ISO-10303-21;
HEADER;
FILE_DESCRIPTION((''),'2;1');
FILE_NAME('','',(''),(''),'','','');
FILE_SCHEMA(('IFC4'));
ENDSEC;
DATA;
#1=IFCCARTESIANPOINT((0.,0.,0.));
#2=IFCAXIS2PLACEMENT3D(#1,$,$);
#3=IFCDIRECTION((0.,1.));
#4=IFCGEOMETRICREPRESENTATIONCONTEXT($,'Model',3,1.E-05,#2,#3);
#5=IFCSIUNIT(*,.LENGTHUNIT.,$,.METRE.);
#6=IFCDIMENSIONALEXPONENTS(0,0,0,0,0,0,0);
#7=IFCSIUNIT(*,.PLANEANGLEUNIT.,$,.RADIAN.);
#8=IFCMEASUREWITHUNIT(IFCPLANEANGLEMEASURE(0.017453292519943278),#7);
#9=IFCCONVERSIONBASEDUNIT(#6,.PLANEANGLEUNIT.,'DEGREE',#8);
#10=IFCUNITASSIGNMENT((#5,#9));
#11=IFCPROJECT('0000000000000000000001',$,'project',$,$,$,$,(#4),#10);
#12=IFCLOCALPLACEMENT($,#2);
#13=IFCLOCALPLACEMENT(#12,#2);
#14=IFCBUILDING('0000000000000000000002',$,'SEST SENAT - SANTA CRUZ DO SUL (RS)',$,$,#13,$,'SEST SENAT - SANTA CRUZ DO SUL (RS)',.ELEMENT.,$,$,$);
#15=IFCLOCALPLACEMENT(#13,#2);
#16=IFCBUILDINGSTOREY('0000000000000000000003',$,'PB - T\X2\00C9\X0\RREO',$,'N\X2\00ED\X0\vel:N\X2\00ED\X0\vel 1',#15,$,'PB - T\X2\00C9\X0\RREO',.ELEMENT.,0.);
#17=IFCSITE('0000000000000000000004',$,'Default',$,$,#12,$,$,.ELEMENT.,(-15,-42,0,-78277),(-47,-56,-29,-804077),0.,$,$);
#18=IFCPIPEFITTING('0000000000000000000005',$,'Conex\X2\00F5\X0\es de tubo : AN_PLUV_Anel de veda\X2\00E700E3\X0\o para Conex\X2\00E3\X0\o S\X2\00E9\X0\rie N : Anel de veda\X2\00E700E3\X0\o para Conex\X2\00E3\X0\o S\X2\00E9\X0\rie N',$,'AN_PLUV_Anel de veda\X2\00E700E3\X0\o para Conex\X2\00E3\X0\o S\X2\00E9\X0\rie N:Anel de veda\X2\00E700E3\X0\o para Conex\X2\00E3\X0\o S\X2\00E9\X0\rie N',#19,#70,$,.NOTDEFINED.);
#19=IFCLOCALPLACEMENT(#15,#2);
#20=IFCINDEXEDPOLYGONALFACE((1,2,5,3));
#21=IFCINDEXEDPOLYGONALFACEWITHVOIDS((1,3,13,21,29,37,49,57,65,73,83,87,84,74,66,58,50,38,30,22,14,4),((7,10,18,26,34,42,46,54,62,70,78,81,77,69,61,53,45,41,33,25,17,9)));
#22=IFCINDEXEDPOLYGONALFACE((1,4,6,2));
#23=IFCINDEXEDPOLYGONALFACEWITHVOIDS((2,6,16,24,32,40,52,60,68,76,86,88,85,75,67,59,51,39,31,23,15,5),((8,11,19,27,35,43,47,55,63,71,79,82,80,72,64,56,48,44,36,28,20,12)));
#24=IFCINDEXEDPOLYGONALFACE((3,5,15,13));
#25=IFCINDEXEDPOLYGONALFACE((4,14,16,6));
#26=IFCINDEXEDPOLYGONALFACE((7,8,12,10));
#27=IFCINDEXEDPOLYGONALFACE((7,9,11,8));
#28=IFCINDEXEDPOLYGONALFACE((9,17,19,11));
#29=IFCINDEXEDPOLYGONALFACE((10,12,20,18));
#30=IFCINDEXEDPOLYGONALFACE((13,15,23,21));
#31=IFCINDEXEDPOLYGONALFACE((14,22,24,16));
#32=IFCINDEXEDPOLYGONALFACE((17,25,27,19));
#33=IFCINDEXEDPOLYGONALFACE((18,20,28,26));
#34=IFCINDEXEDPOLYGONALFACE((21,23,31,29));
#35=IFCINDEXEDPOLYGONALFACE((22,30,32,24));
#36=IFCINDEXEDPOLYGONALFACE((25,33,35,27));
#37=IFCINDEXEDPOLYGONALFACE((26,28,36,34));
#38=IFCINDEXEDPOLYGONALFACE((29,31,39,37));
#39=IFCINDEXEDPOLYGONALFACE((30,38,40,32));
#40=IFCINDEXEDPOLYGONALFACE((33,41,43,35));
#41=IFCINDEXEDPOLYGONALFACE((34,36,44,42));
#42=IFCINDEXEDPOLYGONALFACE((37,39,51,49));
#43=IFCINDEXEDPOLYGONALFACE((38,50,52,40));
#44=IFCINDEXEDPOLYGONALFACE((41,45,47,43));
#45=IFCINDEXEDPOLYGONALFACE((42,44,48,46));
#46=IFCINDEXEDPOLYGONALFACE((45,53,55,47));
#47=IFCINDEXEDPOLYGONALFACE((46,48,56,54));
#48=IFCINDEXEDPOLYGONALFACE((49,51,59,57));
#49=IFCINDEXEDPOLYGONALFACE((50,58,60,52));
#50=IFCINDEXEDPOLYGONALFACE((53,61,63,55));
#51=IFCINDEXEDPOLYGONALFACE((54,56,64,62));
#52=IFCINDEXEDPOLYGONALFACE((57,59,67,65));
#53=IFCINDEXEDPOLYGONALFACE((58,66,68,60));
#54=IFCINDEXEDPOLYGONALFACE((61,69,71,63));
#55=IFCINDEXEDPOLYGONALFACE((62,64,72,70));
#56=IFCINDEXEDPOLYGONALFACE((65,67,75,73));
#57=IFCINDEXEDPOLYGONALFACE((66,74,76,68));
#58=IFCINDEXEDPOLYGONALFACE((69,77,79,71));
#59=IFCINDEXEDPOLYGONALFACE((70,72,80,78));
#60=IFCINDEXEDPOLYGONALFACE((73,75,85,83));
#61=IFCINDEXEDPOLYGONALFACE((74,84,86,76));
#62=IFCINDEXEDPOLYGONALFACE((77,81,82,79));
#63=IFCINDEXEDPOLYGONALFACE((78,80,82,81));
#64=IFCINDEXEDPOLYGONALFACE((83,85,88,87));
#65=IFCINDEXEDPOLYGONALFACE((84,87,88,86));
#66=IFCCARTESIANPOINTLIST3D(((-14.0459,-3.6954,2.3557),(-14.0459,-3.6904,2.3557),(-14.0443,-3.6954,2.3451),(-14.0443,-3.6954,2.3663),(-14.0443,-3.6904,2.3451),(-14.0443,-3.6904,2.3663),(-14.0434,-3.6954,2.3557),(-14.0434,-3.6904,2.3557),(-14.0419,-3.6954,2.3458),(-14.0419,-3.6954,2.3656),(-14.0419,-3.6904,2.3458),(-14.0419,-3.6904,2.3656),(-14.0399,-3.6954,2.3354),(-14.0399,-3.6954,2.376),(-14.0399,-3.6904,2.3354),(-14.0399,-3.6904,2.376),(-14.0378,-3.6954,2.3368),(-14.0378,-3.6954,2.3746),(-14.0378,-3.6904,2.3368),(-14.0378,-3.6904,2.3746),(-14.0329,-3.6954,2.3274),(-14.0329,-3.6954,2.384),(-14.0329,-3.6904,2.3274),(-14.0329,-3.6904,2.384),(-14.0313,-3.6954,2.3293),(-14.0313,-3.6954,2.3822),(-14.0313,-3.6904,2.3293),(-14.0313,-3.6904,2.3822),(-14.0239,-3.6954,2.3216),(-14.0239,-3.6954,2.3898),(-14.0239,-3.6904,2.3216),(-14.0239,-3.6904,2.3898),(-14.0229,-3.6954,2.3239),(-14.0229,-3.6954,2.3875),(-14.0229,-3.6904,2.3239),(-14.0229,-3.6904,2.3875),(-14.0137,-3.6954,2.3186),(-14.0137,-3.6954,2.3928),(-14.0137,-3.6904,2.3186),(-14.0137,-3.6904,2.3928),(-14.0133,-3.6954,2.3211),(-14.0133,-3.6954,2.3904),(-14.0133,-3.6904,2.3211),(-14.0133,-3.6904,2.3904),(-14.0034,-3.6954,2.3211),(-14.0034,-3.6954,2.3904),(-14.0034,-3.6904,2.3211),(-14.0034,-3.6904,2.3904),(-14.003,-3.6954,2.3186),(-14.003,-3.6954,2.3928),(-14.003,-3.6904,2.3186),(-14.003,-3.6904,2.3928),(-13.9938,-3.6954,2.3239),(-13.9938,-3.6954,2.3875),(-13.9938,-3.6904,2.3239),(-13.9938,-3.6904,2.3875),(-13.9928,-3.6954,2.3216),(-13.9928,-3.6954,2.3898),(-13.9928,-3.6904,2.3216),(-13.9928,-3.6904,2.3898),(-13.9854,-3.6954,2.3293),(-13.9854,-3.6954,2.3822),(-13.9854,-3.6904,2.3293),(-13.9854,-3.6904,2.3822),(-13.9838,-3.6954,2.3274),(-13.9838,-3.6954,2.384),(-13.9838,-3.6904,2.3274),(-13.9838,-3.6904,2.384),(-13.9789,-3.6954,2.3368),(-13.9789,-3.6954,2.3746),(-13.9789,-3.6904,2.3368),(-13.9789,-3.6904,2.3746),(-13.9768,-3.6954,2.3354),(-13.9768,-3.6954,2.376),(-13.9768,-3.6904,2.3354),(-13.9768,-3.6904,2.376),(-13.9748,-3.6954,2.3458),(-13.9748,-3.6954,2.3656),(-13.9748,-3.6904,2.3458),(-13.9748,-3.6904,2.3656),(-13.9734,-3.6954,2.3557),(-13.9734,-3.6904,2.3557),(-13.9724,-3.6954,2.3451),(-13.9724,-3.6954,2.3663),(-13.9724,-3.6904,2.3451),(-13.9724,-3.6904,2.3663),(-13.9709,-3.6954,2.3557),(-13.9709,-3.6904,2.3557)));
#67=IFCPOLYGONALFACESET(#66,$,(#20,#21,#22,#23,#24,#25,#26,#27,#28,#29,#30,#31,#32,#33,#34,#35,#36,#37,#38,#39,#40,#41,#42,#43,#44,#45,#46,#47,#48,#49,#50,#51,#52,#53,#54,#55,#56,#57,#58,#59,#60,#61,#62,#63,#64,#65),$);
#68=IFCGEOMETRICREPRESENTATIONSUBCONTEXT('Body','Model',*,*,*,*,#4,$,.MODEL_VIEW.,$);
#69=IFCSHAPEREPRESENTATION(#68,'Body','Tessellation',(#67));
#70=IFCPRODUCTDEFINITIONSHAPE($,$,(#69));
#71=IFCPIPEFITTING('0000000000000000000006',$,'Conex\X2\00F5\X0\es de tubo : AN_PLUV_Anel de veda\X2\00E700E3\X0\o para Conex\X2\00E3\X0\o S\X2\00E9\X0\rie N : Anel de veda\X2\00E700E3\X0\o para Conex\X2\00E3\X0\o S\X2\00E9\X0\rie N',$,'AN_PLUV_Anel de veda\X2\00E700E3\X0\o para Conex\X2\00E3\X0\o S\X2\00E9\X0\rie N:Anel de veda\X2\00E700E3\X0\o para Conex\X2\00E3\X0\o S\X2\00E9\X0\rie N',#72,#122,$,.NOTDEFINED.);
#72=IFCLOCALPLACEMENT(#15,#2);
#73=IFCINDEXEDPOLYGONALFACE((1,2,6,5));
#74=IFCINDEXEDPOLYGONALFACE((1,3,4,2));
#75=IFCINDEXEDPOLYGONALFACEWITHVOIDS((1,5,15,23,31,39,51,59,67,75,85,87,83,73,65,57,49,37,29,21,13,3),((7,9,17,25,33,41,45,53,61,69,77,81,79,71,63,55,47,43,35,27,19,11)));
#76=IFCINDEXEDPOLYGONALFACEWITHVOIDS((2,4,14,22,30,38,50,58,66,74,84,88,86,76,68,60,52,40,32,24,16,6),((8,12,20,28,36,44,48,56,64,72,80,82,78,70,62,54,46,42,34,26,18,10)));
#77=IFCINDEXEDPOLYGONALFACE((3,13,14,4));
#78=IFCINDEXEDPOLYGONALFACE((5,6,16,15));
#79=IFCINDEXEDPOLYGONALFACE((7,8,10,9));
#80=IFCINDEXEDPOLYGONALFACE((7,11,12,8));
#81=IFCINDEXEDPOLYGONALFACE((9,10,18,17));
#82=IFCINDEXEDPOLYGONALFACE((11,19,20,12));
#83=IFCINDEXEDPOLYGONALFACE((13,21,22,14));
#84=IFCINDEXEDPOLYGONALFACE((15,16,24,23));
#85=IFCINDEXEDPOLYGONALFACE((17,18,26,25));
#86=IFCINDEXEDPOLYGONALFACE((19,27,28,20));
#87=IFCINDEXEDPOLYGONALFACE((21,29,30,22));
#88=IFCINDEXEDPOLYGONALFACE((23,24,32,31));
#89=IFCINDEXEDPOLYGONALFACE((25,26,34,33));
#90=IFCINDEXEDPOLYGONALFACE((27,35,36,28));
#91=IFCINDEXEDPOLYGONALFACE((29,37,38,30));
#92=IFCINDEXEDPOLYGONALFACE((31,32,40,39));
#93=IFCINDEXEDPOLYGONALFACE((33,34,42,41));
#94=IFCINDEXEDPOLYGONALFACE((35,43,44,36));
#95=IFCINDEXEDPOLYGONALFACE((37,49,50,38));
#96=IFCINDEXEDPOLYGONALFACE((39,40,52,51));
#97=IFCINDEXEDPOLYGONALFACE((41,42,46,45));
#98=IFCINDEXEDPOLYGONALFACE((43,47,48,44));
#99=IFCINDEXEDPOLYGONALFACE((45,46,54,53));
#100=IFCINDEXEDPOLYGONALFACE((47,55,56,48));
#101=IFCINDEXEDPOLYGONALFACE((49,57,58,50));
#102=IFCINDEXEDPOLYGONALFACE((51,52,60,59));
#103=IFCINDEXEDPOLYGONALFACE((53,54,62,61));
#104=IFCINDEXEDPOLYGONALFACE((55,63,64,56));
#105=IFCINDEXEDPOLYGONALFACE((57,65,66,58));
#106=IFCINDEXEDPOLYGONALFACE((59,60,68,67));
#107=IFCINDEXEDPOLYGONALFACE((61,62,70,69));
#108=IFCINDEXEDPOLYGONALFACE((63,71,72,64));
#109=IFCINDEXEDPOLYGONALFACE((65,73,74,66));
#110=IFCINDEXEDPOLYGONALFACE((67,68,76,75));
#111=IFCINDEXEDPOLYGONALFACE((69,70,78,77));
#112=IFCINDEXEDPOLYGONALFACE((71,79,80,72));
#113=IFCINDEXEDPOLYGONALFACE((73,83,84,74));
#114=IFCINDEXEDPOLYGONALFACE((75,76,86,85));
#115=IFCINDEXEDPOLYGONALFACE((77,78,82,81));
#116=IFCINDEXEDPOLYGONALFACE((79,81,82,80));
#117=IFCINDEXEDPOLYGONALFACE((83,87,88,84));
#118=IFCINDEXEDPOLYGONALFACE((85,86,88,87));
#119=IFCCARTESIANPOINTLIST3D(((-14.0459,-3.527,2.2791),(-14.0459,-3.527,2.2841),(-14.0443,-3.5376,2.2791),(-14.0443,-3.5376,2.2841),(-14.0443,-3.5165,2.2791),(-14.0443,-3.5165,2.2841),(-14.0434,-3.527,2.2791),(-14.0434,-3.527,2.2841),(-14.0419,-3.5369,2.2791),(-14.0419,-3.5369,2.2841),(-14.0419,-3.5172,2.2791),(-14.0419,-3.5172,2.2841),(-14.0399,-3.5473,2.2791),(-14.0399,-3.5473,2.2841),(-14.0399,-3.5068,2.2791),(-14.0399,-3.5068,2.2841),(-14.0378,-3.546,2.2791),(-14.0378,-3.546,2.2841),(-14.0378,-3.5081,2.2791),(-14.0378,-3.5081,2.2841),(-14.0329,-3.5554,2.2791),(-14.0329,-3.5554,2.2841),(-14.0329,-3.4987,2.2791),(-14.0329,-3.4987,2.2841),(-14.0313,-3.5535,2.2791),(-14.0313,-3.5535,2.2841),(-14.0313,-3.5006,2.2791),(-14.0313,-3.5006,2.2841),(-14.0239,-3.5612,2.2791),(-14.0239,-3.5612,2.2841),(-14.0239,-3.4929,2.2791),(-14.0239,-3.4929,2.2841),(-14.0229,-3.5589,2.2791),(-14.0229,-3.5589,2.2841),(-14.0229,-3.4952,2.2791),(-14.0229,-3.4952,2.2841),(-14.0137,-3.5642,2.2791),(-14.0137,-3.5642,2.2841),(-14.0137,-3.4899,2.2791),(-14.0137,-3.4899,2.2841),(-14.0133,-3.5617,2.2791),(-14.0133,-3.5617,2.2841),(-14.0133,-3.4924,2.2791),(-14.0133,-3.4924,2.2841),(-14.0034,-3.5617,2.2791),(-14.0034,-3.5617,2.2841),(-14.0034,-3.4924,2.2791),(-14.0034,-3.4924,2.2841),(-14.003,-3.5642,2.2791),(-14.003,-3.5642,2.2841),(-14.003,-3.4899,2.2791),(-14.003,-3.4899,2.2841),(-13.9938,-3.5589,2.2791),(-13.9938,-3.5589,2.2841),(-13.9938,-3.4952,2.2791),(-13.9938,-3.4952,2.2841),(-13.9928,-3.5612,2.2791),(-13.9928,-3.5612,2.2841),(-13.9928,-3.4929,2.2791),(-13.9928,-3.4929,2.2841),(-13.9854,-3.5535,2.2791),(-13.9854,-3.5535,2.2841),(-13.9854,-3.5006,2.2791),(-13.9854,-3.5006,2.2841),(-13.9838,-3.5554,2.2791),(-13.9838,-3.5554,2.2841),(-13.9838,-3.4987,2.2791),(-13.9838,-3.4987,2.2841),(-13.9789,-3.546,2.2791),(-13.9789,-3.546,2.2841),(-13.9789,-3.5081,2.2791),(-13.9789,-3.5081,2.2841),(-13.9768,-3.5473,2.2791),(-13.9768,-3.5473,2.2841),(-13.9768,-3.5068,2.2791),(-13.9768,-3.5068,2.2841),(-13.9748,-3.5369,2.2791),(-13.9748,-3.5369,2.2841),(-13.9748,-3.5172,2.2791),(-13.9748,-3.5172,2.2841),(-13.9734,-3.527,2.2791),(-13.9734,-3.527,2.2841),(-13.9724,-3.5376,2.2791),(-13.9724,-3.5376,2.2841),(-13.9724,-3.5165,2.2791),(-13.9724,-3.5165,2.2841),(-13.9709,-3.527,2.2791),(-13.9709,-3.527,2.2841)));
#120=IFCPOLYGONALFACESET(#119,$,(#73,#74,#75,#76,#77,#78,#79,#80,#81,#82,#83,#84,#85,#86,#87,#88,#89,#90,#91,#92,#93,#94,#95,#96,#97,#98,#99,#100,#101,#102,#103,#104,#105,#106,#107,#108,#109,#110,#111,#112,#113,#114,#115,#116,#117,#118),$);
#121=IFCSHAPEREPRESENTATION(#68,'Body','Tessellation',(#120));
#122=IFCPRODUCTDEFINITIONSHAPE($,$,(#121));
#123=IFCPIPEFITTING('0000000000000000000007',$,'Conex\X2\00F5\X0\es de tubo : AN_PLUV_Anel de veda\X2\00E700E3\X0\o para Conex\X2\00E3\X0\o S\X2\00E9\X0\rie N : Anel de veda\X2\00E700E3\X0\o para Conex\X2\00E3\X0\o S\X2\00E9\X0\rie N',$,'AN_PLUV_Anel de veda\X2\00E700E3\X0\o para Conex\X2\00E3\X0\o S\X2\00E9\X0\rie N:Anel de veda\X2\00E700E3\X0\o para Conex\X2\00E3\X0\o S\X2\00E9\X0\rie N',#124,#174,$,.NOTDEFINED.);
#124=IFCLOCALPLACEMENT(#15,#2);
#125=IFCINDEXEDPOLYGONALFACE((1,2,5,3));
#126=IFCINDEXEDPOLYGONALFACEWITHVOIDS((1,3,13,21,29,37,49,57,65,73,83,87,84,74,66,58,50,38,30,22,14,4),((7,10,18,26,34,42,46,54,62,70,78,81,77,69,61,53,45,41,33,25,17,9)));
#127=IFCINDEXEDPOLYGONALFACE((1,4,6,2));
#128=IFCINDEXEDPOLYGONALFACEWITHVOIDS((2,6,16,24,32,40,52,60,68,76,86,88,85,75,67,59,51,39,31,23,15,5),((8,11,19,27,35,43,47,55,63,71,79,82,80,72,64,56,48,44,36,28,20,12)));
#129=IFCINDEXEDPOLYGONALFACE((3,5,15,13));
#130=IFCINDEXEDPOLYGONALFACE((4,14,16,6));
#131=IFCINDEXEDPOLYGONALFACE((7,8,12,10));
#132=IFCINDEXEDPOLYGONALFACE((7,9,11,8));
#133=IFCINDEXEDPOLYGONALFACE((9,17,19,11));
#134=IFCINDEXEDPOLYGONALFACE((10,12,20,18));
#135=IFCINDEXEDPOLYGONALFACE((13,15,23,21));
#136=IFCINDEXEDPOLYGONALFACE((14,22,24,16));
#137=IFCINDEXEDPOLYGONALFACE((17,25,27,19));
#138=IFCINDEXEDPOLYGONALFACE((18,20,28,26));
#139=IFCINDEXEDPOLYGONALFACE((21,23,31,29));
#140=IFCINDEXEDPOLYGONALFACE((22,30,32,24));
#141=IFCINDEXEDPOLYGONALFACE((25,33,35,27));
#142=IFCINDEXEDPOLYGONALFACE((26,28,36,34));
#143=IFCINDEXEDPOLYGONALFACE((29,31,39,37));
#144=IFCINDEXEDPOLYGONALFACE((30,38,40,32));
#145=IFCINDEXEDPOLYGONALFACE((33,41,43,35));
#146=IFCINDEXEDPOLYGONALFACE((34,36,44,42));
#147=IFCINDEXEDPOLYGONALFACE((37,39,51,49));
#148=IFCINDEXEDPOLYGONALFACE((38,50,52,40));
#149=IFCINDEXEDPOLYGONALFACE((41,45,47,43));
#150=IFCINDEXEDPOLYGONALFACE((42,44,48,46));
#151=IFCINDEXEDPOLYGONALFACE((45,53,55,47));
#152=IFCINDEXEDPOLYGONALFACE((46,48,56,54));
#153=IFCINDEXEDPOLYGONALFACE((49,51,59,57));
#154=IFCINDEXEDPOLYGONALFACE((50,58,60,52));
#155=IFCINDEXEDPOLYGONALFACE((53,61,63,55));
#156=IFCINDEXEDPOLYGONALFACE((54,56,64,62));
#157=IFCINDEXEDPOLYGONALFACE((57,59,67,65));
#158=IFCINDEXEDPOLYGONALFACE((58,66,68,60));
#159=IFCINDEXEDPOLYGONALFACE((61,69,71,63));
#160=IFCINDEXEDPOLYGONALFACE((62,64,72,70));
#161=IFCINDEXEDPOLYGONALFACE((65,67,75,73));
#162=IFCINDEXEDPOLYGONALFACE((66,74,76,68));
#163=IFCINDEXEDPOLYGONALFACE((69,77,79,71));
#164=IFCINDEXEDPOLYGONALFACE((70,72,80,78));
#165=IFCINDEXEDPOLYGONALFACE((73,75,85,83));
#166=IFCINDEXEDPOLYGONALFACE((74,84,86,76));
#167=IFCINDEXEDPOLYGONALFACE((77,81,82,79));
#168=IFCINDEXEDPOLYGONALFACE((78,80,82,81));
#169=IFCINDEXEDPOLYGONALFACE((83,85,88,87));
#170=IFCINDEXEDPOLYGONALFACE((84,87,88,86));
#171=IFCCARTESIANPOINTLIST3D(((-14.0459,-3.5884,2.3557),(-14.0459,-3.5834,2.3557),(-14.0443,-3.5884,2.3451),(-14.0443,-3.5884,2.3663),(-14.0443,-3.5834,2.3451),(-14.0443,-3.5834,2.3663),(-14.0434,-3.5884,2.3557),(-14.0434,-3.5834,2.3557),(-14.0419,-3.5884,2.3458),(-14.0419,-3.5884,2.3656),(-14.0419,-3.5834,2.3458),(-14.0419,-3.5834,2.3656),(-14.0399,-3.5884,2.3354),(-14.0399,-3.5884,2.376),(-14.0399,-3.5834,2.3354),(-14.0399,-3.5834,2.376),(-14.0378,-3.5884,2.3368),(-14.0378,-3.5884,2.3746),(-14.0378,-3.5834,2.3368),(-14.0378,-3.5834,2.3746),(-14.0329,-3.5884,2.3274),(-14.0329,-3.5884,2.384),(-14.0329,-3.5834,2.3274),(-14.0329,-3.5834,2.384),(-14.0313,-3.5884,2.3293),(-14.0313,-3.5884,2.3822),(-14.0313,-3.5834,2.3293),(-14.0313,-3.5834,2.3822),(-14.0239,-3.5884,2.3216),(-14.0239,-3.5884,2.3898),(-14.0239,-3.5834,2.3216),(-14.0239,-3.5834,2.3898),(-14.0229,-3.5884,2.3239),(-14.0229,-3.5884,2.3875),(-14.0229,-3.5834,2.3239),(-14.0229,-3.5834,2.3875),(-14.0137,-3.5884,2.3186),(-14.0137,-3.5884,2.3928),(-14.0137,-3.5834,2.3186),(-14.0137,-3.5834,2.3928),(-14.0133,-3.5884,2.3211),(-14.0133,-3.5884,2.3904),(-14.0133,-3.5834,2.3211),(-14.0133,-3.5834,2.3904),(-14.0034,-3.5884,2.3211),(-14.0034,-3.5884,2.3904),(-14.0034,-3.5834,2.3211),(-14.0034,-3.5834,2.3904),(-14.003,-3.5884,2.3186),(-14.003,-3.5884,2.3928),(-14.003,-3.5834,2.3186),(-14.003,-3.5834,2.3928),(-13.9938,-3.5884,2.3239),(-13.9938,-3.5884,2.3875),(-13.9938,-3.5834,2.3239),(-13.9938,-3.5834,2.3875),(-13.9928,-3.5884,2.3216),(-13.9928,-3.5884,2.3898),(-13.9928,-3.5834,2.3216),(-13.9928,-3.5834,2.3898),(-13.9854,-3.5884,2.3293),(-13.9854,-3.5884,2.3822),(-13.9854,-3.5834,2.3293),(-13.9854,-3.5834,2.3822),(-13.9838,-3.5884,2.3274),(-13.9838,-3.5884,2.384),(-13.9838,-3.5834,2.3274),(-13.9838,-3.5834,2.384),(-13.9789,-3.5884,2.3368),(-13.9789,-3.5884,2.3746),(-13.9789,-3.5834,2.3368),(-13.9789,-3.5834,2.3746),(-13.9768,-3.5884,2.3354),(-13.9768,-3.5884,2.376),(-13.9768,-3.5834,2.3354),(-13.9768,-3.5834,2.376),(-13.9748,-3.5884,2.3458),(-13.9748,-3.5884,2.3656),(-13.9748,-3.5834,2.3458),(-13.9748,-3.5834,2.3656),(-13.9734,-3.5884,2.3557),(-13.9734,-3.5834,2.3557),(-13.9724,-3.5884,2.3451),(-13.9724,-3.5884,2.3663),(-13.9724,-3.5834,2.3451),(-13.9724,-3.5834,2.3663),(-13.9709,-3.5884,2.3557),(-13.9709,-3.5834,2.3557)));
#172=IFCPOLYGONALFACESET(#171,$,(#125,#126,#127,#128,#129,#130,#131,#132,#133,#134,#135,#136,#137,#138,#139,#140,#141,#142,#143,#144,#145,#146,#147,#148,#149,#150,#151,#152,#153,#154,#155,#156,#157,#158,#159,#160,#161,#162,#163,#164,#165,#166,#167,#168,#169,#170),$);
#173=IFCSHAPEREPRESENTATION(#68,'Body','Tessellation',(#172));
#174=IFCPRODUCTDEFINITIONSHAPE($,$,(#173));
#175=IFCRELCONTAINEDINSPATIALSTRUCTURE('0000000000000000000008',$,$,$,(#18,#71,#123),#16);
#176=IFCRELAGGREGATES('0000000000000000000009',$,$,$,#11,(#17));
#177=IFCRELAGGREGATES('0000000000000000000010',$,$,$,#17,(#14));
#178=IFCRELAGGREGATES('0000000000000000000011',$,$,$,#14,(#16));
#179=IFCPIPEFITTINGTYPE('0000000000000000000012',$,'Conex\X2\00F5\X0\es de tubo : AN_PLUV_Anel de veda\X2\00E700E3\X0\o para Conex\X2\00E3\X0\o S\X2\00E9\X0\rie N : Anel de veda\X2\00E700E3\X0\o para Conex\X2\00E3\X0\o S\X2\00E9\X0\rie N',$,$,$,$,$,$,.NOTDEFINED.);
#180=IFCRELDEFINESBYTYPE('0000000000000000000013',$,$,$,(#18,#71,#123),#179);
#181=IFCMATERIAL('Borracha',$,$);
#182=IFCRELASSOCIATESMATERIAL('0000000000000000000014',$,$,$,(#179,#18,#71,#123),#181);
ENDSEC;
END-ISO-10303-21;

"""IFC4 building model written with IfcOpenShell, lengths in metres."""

from ifc_helpers import new_model, entity, si_unit, converted_unit, direction, frame, origin, place, context, subcontext, project, spatial, arc, indexed_curve, outline, extrude, source, transform, mapped, material, type_object, type_shapes, element, save


model = new_model("IFC4")

# Units and contexts
model_context = context("Model", 3, precision=1e-05, world=origin(), true_north=direction((0.0, 1.0)))
body_context = subcontext(model_context, "Body", "Model", "MODEL_VIEW")
ifc_project = project(units=[si_unit("LENGTHUNIT", "METRE"), converted_unit("PLANEANGLEUNIT", "DEGREE", entity("IfcPlaneAngleMeasure", 0.017453292519943278), si_unit("PLANEANGLEUNIT", "RADIAN"), dimensions=[0, 0, 0, 0, 0, 0, 0])], contexts=[model_context])

# Site, building, storey
site_placement = place(None, origin())
site = spatial("IfcSite", under=ifc_project, at=site_placement, Name="Default", CompositionType="ELEMENT", RefLatitude=(-15, -42, 0, -78277), RefLongitude=(-47, -56, -29, -804077), RefElevation=0.0)
building_placement = place(site_placement, origin())
building = spatial("IfcBuilding", under=site, at=building_placement, Name="SEST SENAT - SANTA CRUZ DO SUL (RS)", LongName="SEST SENAT - SANTA CRUZ DO SUL (RS)", CompositionType="ELEMENT")
storey_placement = place(building_placement, origin())
storey = spatial("IfcBuildingStorey", under=building, at=storey_placement, Name="PB - TÉRREO", ObjectType="Nível:Nível 1", LongName="PB - TÉRREO", CompositionType="ELEMENT", Elevation=0.0)

# Shared definitions
ifc_material_1 = material(Name="Borracha")

# Pipe fittings
pipe_fitting_type_1 = type_object("IfcPipeFittingType", Name="Conexões de tubo : AN_PLUV_Anel de vedação para Conexão Série N : Anel de vedação para Conexão Série N", PredefinedType="NOTDEFINED", material=ifc_material_1)
shared_shape_1 = source(origin(), body_context, "Body", "SweptSolid", [
    extrude(outline(indexed_curve([(-0.0375, 0.0), (0.0, -0.0375), (0.0375, 0.0), (0.0, 0.0375)], segments=[arc(1, 2, 3), arc(3, 4, 1)], self_intersect=False), holes=[indexed_curve([(-0.035, 0.0), (0.0, 0.035), (0.035, 0.0), (0.0, -0.035)], segments=[arc(1, 2, 3), arc(3, 4, 1)], self_intersect=False)]), frame((0.0, 0.0, -0.005)), (0.0, 0.0, 1.0), 0.005),
])
type_shapes(pipe_fitting_type_1, [shared_shape_1])
for number, where, z_axis, x_axis, name in (
    (1, (-14.0084, -3.6904, 2.3557), (0.0, 1.0, 0.0), (-1.0, 0.0, 0.0), "Conexões de tubo : AN_PLUV_Anel de vedação para Conexão Série N : Anel de vedação para Conexão Série N"),
    (2, (-14.0084, -3.527, 2.2791), (0.0, 0.0, -1.0), (1.0, 0.0, 0.0), "Conexões de tubo : AN_PLUV_Anel de vedação para Conexão Série N : Anel de vedação para Conexão Série N"),
    (3, (-14.0084, -3.5834, 2.3557), (0.0, 1.0, 0.0), (1.0, 0.0, 0.0), "Conexões de tubo : AN_PLUV_Anel de vedação para Conexão Série N : Anel de vedação para Conexão Série N"),
):
    element("IfcPipeFitting", number, at=place(storey_placement, frame(where, z_axis=z_axis, x_axis=x_axis)), inside=storey, type_object=pipe_fitting_type_1, material=ifc_material_1, Name=name, ObjectType="AN_PLUV_Anel de vedação para Conexão Série N:Anel de vedação para Conexão Série N", PredefinedType="NOTDEFINED", context=body_context, shape_type="MappedRepresentation", body=[
        mapped(shared_shape_1, transform((0.0, 0.0, 0.0), scale=1.0)),
    ])

save(model, "model.ifc")
